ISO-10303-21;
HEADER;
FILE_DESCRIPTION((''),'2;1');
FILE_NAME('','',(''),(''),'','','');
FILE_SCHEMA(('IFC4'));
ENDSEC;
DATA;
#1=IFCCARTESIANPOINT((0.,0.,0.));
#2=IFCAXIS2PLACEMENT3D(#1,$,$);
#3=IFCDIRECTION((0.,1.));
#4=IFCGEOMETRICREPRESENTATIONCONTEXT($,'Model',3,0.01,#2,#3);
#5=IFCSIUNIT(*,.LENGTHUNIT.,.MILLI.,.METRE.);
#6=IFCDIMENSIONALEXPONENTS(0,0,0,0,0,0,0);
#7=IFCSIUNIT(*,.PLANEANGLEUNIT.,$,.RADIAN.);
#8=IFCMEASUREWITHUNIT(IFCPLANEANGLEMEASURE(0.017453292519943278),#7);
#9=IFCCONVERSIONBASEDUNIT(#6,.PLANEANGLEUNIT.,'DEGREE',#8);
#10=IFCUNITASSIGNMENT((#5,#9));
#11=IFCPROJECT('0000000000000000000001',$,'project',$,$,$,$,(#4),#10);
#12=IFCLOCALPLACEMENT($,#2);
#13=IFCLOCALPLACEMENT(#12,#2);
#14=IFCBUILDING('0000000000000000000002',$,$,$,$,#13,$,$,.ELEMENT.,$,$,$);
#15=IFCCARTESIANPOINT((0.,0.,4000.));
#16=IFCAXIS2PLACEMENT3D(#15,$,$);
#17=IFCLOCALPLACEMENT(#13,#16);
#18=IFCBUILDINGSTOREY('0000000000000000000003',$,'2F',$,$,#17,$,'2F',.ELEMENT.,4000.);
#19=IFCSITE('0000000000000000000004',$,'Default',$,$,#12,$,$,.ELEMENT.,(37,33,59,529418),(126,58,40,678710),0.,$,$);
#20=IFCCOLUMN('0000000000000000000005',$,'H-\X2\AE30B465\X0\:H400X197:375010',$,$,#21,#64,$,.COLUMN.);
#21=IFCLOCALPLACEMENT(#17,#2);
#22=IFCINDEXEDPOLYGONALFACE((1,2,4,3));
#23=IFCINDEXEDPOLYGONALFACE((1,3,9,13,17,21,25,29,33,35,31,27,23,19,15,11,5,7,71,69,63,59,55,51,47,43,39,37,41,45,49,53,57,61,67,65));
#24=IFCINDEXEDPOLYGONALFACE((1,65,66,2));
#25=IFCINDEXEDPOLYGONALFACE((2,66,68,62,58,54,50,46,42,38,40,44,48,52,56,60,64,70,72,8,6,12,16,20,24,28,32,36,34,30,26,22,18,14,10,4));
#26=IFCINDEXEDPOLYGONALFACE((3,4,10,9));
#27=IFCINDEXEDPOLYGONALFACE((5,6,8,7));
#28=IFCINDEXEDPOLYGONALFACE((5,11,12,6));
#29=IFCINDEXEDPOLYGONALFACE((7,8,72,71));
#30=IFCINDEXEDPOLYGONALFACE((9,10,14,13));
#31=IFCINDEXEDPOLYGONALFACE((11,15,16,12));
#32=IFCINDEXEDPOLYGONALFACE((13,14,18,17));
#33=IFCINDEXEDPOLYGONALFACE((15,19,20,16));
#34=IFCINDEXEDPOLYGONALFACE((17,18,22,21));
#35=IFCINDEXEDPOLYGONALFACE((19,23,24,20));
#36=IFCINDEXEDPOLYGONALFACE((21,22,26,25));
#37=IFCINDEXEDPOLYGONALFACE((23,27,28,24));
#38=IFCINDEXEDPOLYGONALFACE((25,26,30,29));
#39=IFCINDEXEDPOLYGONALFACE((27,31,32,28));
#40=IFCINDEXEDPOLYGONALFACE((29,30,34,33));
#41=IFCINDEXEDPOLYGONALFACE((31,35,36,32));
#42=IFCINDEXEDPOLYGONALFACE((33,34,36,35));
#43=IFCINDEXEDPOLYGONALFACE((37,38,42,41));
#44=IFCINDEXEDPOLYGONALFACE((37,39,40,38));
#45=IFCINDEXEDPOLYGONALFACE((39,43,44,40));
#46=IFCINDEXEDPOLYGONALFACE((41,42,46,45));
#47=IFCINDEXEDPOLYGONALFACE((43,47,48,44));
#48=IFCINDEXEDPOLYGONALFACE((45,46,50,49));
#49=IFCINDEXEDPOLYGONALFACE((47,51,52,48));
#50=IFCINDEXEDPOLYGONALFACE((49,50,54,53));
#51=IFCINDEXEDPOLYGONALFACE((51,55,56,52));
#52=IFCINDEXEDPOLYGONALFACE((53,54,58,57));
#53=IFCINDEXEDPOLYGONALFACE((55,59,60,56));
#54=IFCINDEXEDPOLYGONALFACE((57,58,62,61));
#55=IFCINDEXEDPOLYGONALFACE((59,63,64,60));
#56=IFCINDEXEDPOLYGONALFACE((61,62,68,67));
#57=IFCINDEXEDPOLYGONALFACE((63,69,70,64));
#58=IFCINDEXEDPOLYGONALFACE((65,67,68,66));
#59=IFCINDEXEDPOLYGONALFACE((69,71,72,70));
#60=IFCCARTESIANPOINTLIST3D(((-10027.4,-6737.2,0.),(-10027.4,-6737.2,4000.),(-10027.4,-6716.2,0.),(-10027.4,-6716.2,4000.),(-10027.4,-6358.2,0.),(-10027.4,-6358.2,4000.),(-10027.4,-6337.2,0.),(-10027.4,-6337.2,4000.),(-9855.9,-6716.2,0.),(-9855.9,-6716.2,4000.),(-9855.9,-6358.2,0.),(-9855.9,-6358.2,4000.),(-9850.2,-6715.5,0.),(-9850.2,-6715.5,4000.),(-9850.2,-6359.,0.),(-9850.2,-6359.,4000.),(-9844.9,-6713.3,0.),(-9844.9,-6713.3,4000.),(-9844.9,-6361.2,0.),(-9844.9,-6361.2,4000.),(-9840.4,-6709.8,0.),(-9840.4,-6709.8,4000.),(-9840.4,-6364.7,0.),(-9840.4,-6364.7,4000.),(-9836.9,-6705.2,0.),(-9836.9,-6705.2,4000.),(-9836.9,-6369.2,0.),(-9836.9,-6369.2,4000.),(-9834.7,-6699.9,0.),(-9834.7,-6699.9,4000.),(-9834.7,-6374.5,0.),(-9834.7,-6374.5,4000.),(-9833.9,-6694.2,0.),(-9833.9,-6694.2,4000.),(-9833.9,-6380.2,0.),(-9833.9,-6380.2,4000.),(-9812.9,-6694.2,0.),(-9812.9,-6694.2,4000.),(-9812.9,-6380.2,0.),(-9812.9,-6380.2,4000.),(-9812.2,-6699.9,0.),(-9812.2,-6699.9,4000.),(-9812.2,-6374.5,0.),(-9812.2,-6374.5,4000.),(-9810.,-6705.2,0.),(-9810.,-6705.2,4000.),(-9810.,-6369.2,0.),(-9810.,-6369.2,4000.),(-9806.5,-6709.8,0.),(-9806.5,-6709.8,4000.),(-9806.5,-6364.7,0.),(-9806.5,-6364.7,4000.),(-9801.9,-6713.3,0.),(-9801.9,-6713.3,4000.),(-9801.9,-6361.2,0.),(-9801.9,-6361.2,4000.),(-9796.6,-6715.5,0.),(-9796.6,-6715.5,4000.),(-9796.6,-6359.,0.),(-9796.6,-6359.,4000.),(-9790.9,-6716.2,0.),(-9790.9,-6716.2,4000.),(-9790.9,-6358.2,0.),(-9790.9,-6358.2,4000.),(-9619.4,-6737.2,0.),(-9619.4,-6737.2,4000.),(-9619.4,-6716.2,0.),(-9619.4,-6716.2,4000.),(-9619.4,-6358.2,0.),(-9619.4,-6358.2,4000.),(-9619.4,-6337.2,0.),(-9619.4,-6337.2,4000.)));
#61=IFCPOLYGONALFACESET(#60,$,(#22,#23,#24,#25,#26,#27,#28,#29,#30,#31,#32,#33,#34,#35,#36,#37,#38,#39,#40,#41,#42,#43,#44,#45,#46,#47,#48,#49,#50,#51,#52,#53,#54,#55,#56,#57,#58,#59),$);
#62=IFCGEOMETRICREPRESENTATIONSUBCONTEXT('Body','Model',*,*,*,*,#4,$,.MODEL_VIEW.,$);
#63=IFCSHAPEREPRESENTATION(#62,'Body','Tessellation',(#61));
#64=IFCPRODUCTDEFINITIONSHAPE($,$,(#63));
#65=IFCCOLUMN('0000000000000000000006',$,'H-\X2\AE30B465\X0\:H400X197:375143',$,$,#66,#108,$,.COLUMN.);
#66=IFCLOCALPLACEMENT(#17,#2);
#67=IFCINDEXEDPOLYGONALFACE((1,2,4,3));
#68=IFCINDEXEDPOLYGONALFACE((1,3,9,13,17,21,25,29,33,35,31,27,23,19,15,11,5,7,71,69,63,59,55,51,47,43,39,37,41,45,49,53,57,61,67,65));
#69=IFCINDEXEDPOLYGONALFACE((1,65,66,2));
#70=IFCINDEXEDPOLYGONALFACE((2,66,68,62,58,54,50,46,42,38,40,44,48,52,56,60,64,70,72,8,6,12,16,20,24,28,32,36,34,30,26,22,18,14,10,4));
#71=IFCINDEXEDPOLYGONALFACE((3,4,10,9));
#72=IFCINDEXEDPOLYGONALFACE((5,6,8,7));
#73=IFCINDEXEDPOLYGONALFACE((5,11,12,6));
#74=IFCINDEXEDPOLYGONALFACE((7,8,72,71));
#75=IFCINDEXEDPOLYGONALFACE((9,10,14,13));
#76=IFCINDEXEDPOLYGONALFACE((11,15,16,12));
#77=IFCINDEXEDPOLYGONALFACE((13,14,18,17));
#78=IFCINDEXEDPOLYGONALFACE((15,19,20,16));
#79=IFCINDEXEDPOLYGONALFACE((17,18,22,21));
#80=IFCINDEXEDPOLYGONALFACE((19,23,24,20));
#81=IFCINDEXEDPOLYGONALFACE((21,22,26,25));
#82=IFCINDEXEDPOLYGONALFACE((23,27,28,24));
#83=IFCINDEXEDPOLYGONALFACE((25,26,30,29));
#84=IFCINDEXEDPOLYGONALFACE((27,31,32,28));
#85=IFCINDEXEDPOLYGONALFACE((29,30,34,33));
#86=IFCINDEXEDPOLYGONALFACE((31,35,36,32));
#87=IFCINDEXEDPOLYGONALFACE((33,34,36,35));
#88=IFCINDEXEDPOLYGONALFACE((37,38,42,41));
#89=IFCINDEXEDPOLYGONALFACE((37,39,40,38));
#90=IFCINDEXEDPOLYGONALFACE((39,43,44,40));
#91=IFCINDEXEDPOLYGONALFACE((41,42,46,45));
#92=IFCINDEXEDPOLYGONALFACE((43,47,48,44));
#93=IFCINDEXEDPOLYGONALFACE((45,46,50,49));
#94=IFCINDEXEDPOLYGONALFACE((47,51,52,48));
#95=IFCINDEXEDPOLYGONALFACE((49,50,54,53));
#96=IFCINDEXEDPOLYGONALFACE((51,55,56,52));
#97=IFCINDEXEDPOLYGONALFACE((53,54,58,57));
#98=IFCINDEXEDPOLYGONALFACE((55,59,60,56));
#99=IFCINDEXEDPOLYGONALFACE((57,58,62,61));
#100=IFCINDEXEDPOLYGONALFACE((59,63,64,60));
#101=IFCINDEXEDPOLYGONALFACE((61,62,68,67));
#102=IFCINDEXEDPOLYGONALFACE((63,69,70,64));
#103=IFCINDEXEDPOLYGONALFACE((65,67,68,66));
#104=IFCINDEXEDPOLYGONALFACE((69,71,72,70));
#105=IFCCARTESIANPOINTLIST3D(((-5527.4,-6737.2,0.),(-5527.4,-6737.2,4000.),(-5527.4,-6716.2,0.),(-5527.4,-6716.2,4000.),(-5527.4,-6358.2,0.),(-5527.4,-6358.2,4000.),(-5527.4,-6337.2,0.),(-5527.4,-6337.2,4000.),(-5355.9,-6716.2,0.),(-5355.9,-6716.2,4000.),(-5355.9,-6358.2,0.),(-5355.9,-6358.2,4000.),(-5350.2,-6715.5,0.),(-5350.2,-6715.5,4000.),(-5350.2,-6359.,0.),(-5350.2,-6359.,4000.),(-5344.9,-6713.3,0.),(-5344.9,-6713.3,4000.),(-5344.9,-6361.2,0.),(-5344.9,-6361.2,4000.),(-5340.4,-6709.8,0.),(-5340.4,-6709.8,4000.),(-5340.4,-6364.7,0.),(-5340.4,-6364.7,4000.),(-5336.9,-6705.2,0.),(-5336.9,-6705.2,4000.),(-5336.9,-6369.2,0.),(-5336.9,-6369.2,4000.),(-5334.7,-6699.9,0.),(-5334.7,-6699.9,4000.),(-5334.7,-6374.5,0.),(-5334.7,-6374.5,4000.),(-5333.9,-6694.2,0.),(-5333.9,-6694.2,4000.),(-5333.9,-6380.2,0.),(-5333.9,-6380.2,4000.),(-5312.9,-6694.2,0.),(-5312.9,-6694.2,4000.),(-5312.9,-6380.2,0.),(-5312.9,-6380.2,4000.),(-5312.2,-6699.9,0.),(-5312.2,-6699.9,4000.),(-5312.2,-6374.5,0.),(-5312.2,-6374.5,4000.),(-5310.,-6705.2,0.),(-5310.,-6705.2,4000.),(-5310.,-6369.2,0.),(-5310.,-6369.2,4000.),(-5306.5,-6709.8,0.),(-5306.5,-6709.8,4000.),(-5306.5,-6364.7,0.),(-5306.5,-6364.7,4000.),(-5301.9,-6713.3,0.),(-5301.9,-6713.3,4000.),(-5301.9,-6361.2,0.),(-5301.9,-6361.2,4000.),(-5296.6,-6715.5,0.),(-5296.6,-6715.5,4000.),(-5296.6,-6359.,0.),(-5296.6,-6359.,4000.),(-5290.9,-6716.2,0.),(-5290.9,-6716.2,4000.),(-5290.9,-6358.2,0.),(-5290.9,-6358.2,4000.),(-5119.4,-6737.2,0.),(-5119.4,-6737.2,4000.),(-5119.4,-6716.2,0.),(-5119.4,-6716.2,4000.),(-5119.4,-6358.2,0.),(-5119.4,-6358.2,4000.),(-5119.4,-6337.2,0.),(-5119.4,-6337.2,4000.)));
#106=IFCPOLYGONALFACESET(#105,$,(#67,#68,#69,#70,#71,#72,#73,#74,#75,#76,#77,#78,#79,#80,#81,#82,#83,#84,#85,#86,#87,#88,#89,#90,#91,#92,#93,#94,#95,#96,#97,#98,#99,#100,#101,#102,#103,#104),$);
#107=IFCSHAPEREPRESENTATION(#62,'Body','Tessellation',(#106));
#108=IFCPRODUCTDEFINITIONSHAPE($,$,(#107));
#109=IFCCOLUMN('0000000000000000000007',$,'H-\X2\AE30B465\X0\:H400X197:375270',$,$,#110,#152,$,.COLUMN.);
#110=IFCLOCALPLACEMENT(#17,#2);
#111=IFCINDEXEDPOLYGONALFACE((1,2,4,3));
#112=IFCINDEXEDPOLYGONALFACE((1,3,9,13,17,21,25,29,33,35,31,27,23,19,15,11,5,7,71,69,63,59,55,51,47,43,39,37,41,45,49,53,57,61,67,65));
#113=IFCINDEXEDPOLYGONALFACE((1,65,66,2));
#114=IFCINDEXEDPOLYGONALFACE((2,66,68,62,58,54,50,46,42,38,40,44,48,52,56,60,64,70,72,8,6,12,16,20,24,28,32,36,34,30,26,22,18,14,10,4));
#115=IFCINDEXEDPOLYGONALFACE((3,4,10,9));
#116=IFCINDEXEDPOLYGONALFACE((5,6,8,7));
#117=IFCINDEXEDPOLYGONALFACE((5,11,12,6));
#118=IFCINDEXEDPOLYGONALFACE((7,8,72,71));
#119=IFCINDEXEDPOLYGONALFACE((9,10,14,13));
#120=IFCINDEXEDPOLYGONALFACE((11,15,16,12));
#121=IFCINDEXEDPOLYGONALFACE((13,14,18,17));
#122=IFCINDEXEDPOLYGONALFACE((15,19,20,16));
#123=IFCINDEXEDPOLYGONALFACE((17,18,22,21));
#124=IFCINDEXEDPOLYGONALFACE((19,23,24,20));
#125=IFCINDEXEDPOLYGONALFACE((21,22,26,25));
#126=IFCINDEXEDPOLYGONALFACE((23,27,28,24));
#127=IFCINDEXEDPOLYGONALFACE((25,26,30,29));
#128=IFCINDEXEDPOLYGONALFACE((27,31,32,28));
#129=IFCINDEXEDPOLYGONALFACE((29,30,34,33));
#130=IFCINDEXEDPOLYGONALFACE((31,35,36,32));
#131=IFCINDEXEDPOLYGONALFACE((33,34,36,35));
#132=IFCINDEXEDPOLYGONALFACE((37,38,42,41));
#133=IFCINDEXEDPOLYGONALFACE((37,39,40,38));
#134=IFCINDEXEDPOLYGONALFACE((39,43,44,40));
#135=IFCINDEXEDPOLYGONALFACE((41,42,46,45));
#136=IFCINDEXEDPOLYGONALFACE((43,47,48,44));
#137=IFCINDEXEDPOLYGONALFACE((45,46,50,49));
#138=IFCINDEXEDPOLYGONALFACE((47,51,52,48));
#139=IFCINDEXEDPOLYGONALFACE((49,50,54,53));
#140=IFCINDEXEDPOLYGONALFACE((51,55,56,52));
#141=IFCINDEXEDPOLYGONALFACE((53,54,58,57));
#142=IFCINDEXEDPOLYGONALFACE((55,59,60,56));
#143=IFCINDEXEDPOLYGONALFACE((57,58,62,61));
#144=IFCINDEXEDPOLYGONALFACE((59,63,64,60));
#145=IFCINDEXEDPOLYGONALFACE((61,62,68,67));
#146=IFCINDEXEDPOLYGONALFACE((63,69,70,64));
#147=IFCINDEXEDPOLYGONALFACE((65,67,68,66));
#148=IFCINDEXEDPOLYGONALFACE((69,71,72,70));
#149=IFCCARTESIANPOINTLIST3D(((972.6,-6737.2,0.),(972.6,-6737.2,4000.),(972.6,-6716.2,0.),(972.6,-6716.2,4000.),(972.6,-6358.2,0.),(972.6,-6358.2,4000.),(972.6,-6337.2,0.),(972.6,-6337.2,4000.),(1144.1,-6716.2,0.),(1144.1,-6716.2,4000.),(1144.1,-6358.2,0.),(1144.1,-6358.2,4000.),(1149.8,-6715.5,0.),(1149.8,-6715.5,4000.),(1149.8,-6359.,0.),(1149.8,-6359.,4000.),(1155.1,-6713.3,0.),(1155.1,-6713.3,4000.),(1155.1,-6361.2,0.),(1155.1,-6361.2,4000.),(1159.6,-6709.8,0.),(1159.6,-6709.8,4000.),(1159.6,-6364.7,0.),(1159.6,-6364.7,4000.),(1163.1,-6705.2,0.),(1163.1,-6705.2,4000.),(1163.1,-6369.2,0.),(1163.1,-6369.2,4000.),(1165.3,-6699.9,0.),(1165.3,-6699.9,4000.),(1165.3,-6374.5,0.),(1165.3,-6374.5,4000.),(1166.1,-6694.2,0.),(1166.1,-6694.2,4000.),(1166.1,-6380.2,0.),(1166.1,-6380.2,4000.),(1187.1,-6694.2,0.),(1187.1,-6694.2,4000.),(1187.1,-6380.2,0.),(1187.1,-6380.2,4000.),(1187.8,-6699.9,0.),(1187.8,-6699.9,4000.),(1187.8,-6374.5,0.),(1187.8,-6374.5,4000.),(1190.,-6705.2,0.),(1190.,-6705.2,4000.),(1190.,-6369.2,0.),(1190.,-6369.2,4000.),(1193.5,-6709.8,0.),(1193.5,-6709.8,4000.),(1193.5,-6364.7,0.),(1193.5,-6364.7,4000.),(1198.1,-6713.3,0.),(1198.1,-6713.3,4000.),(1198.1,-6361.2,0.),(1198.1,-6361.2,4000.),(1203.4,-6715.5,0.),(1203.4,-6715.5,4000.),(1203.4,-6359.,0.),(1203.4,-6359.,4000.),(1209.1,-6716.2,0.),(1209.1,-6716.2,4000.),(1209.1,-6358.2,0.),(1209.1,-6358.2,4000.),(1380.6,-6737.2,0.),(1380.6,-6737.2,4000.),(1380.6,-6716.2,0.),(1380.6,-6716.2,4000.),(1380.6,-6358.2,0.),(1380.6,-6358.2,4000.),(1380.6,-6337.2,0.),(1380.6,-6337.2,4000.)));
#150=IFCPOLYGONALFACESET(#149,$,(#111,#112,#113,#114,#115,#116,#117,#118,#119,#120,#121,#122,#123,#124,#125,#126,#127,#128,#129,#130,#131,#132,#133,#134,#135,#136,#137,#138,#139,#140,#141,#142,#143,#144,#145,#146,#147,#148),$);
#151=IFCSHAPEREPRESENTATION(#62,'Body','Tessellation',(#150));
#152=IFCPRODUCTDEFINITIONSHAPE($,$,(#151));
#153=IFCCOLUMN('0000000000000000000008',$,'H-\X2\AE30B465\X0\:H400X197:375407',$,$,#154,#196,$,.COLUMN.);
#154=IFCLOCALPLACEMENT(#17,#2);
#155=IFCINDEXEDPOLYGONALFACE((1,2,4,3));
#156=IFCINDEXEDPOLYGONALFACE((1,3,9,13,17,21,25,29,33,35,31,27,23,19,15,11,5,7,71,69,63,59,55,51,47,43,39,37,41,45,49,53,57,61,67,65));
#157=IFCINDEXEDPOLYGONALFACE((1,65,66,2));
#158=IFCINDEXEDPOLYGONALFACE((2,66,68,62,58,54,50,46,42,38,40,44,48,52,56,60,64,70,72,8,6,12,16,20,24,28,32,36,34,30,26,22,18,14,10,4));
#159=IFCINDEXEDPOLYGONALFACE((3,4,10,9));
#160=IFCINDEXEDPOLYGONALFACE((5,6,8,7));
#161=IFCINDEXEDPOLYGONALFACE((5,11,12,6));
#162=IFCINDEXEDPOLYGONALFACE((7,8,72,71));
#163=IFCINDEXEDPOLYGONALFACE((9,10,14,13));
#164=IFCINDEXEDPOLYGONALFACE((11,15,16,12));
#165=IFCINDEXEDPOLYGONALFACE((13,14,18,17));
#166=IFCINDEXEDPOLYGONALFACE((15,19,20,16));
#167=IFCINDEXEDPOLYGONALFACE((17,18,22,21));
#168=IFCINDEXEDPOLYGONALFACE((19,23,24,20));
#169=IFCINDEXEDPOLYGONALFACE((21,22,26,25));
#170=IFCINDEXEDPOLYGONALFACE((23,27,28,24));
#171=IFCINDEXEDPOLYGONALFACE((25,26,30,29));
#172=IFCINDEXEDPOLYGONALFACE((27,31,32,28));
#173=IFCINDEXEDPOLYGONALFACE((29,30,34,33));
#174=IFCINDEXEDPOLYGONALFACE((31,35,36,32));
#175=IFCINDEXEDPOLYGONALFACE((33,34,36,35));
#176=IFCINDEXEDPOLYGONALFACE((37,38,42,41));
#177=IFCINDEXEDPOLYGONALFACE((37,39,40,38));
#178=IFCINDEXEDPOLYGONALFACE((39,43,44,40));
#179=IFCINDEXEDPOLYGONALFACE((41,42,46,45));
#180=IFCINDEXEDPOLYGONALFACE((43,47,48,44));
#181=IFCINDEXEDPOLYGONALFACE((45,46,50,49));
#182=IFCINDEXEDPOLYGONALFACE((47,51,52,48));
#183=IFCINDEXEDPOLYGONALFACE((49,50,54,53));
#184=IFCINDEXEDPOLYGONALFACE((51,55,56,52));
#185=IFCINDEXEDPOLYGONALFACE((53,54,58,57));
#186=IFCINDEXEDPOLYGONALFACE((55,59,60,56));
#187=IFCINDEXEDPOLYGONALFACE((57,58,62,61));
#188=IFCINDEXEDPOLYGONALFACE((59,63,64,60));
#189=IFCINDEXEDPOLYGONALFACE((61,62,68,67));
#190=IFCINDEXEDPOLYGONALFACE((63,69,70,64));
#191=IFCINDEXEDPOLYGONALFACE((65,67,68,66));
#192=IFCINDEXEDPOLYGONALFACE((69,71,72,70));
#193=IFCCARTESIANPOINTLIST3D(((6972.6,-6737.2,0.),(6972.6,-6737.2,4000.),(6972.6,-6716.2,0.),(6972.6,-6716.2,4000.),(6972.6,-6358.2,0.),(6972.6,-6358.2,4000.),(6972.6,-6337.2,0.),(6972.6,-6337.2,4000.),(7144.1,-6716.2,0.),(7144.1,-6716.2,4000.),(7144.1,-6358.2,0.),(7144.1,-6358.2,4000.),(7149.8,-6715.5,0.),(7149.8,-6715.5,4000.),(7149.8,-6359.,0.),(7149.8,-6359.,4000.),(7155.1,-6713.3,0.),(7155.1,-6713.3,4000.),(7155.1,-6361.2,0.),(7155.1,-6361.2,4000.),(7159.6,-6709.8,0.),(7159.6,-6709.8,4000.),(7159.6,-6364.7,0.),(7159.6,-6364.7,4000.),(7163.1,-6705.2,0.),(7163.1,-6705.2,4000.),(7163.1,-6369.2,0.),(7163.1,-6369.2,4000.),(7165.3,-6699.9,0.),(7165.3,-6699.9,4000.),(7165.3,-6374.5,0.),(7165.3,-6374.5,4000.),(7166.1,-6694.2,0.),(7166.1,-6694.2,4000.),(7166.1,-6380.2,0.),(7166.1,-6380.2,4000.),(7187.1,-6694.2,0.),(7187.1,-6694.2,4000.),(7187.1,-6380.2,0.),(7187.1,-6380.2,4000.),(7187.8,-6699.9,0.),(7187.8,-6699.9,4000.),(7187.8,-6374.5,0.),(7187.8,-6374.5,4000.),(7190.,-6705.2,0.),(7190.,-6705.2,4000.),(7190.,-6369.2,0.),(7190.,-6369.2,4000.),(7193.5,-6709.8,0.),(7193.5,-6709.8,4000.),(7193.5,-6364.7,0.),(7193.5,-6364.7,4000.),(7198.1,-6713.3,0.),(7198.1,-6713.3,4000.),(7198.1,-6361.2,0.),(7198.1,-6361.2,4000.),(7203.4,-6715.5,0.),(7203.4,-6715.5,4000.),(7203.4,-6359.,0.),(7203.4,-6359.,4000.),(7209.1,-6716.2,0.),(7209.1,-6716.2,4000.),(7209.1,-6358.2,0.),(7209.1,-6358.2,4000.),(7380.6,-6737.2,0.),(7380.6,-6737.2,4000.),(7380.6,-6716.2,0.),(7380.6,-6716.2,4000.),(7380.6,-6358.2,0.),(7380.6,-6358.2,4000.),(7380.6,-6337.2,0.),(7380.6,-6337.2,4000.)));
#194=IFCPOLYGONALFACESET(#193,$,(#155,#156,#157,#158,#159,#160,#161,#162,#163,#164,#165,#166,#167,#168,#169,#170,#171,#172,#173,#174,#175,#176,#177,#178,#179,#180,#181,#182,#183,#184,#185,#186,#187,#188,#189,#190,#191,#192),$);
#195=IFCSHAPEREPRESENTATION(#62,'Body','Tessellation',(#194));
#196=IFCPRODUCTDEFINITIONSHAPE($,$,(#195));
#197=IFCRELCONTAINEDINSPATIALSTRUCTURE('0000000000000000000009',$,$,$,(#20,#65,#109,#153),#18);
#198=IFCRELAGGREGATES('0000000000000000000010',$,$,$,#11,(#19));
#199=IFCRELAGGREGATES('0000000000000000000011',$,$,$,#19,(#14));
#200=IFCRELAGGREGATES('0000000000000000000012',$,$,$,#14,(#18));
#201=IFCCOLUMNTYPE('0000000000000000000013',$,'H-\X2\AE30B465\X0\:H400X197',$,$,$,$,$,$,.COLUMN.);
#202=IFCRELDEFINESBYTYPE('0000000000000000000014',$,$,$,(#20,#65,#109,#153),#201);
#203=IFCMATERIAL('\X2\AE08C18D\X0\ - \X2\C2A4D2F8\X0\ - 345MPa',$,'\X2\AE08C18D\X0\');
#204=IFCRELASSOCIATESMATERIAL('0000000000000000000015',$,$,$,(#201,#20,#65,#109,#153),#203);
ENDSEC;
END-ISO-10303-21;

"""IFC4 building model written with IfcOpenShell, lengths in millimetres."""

from ifc_helpers import new_model, entity, si_unit, converted_unit, direction, frame, origin, place, context, subcontext, project, spatial, line, arc, indexed_curve, outline, extrude, source, transform, mapped, material, type_object, type_shapes, element, save


model = new_model("IFC4")

# Units and contexts
model_context = context("Model", 3, precision=0.01, world=origin(), true_north=direction((0.0, 1.0)))
body_context = subcontext(model_context, "Body", "Model", "MODEL_VIEW")
ifc_project = project(units=[si_unit("LENGTHUNIT", "METRE", prefix="MILLI"), converted_unit("PLANEANGLEUNIT", "DEGREE", entity("IfcPlaneAngleMeasure", 0.017453292519943278), si_unit("PLANEANGLEUNIT", "RADIAN"), dimensions=[0, 0, 0, 0, 0, 0, 0])], contexts=[model_context])

# Site, building, storey
site_placement = place(None, origin())
site = spatial("IfcSite", under=ifc_project, at=site_placement, Name="Default", CompositionType="ELEMENT", RefLatitude=(37, 33, 59, 529418), RefLongitude=(126, 58, 40, 678710), RefElevation=0.0)
building_placement = place(site_placement, origin())
building = spatial("IfcBuilding", under=site, at=building_placement, CompositionType="ELEMENT")
storey_placement = place(building_placement, frame((0.0, 0.0, 4000.0)))
storey = spatial("IfcBuildingStorey", under=building, at=storey_placement, Name="2F", LongName="2F", CompositionType="ELEMENT", Elevation=4000.0)

# Columns
ifc_material = material(Name="금속 - 스틸 - 345MPa", Category="금속")
column_type = type_object("IfcColumnType", Name="H-기둥:H400X197", PredefinedType="COLUMN", material=ifc_material)
shared_shape_1 = source(origin(), body_context, "Body", "SweptSolid", [
    extrude(outline(indexed_curve([(-204.0, -200.0), (204.0, -200.0), (204.0, -179.0), (32.5, -179.0), (16.9, -172.6), (10.5, -157.0), (10.5, 157.0), (16.9, 172.6), (32.5, 179.0), (204.0, 179.0), (204.0, 200.0), (-204.0, 200.0), (-204.0, 179.0), (-32.5, 179.0), (-16.9, 172.6), (-10.5, 157.0), (-10.5, -157.0), (-16.9, -172.6), (-32.5, -179.0), (-204.0, -179.0)], segments=[line(1, 2, 3, 4), arc(4, 5, 6), line(6, 7), arc(7, 8, 9), line(9, 10, 11, 12, 13, 14), arc(14, 15, 16), line(16, 17), arc(17, 18, 19), line(19, 20, 1)], self_intersect=False)), frame((0.0, 0.0, 4000.0), z_axis=(0.0, 0.0, 1.0), x_axis=(-1.0, 0.0, 0.0)), (0.0, 0.0, 1.0), 4000.0),
])
type_shapes(column_type, [shared_shape_1])
for number, where, name in (
    (1, (-9823.4, -6537.2, -4000.0), "H-기둥:H400X197:375010"),
    (2, (-5323.4, -6537.2, -4000.0), "H-기둥:H400X197:375143"),
    (3, (1176.6, -6537.2, -4000.0), "H-기둥:H400X197:375270"),
    (4, (7176.6, -6537.2, -4000.0), "H-기둥:H400X197:375407"),
):
    element("IfcColumn", number, at=place(storey_placement, frame(where)), inside=storey, type_object=column_type, material=ifc_material, Name=name, PredefinedType="COLUMN", context=body_context, shape_type="MappedRepresentation", body=[
        mapped(shared_shape_1, transform((0.0, 0.0, 0.0), scale=1.0)),
    ])

save(model, "model.ifc")
